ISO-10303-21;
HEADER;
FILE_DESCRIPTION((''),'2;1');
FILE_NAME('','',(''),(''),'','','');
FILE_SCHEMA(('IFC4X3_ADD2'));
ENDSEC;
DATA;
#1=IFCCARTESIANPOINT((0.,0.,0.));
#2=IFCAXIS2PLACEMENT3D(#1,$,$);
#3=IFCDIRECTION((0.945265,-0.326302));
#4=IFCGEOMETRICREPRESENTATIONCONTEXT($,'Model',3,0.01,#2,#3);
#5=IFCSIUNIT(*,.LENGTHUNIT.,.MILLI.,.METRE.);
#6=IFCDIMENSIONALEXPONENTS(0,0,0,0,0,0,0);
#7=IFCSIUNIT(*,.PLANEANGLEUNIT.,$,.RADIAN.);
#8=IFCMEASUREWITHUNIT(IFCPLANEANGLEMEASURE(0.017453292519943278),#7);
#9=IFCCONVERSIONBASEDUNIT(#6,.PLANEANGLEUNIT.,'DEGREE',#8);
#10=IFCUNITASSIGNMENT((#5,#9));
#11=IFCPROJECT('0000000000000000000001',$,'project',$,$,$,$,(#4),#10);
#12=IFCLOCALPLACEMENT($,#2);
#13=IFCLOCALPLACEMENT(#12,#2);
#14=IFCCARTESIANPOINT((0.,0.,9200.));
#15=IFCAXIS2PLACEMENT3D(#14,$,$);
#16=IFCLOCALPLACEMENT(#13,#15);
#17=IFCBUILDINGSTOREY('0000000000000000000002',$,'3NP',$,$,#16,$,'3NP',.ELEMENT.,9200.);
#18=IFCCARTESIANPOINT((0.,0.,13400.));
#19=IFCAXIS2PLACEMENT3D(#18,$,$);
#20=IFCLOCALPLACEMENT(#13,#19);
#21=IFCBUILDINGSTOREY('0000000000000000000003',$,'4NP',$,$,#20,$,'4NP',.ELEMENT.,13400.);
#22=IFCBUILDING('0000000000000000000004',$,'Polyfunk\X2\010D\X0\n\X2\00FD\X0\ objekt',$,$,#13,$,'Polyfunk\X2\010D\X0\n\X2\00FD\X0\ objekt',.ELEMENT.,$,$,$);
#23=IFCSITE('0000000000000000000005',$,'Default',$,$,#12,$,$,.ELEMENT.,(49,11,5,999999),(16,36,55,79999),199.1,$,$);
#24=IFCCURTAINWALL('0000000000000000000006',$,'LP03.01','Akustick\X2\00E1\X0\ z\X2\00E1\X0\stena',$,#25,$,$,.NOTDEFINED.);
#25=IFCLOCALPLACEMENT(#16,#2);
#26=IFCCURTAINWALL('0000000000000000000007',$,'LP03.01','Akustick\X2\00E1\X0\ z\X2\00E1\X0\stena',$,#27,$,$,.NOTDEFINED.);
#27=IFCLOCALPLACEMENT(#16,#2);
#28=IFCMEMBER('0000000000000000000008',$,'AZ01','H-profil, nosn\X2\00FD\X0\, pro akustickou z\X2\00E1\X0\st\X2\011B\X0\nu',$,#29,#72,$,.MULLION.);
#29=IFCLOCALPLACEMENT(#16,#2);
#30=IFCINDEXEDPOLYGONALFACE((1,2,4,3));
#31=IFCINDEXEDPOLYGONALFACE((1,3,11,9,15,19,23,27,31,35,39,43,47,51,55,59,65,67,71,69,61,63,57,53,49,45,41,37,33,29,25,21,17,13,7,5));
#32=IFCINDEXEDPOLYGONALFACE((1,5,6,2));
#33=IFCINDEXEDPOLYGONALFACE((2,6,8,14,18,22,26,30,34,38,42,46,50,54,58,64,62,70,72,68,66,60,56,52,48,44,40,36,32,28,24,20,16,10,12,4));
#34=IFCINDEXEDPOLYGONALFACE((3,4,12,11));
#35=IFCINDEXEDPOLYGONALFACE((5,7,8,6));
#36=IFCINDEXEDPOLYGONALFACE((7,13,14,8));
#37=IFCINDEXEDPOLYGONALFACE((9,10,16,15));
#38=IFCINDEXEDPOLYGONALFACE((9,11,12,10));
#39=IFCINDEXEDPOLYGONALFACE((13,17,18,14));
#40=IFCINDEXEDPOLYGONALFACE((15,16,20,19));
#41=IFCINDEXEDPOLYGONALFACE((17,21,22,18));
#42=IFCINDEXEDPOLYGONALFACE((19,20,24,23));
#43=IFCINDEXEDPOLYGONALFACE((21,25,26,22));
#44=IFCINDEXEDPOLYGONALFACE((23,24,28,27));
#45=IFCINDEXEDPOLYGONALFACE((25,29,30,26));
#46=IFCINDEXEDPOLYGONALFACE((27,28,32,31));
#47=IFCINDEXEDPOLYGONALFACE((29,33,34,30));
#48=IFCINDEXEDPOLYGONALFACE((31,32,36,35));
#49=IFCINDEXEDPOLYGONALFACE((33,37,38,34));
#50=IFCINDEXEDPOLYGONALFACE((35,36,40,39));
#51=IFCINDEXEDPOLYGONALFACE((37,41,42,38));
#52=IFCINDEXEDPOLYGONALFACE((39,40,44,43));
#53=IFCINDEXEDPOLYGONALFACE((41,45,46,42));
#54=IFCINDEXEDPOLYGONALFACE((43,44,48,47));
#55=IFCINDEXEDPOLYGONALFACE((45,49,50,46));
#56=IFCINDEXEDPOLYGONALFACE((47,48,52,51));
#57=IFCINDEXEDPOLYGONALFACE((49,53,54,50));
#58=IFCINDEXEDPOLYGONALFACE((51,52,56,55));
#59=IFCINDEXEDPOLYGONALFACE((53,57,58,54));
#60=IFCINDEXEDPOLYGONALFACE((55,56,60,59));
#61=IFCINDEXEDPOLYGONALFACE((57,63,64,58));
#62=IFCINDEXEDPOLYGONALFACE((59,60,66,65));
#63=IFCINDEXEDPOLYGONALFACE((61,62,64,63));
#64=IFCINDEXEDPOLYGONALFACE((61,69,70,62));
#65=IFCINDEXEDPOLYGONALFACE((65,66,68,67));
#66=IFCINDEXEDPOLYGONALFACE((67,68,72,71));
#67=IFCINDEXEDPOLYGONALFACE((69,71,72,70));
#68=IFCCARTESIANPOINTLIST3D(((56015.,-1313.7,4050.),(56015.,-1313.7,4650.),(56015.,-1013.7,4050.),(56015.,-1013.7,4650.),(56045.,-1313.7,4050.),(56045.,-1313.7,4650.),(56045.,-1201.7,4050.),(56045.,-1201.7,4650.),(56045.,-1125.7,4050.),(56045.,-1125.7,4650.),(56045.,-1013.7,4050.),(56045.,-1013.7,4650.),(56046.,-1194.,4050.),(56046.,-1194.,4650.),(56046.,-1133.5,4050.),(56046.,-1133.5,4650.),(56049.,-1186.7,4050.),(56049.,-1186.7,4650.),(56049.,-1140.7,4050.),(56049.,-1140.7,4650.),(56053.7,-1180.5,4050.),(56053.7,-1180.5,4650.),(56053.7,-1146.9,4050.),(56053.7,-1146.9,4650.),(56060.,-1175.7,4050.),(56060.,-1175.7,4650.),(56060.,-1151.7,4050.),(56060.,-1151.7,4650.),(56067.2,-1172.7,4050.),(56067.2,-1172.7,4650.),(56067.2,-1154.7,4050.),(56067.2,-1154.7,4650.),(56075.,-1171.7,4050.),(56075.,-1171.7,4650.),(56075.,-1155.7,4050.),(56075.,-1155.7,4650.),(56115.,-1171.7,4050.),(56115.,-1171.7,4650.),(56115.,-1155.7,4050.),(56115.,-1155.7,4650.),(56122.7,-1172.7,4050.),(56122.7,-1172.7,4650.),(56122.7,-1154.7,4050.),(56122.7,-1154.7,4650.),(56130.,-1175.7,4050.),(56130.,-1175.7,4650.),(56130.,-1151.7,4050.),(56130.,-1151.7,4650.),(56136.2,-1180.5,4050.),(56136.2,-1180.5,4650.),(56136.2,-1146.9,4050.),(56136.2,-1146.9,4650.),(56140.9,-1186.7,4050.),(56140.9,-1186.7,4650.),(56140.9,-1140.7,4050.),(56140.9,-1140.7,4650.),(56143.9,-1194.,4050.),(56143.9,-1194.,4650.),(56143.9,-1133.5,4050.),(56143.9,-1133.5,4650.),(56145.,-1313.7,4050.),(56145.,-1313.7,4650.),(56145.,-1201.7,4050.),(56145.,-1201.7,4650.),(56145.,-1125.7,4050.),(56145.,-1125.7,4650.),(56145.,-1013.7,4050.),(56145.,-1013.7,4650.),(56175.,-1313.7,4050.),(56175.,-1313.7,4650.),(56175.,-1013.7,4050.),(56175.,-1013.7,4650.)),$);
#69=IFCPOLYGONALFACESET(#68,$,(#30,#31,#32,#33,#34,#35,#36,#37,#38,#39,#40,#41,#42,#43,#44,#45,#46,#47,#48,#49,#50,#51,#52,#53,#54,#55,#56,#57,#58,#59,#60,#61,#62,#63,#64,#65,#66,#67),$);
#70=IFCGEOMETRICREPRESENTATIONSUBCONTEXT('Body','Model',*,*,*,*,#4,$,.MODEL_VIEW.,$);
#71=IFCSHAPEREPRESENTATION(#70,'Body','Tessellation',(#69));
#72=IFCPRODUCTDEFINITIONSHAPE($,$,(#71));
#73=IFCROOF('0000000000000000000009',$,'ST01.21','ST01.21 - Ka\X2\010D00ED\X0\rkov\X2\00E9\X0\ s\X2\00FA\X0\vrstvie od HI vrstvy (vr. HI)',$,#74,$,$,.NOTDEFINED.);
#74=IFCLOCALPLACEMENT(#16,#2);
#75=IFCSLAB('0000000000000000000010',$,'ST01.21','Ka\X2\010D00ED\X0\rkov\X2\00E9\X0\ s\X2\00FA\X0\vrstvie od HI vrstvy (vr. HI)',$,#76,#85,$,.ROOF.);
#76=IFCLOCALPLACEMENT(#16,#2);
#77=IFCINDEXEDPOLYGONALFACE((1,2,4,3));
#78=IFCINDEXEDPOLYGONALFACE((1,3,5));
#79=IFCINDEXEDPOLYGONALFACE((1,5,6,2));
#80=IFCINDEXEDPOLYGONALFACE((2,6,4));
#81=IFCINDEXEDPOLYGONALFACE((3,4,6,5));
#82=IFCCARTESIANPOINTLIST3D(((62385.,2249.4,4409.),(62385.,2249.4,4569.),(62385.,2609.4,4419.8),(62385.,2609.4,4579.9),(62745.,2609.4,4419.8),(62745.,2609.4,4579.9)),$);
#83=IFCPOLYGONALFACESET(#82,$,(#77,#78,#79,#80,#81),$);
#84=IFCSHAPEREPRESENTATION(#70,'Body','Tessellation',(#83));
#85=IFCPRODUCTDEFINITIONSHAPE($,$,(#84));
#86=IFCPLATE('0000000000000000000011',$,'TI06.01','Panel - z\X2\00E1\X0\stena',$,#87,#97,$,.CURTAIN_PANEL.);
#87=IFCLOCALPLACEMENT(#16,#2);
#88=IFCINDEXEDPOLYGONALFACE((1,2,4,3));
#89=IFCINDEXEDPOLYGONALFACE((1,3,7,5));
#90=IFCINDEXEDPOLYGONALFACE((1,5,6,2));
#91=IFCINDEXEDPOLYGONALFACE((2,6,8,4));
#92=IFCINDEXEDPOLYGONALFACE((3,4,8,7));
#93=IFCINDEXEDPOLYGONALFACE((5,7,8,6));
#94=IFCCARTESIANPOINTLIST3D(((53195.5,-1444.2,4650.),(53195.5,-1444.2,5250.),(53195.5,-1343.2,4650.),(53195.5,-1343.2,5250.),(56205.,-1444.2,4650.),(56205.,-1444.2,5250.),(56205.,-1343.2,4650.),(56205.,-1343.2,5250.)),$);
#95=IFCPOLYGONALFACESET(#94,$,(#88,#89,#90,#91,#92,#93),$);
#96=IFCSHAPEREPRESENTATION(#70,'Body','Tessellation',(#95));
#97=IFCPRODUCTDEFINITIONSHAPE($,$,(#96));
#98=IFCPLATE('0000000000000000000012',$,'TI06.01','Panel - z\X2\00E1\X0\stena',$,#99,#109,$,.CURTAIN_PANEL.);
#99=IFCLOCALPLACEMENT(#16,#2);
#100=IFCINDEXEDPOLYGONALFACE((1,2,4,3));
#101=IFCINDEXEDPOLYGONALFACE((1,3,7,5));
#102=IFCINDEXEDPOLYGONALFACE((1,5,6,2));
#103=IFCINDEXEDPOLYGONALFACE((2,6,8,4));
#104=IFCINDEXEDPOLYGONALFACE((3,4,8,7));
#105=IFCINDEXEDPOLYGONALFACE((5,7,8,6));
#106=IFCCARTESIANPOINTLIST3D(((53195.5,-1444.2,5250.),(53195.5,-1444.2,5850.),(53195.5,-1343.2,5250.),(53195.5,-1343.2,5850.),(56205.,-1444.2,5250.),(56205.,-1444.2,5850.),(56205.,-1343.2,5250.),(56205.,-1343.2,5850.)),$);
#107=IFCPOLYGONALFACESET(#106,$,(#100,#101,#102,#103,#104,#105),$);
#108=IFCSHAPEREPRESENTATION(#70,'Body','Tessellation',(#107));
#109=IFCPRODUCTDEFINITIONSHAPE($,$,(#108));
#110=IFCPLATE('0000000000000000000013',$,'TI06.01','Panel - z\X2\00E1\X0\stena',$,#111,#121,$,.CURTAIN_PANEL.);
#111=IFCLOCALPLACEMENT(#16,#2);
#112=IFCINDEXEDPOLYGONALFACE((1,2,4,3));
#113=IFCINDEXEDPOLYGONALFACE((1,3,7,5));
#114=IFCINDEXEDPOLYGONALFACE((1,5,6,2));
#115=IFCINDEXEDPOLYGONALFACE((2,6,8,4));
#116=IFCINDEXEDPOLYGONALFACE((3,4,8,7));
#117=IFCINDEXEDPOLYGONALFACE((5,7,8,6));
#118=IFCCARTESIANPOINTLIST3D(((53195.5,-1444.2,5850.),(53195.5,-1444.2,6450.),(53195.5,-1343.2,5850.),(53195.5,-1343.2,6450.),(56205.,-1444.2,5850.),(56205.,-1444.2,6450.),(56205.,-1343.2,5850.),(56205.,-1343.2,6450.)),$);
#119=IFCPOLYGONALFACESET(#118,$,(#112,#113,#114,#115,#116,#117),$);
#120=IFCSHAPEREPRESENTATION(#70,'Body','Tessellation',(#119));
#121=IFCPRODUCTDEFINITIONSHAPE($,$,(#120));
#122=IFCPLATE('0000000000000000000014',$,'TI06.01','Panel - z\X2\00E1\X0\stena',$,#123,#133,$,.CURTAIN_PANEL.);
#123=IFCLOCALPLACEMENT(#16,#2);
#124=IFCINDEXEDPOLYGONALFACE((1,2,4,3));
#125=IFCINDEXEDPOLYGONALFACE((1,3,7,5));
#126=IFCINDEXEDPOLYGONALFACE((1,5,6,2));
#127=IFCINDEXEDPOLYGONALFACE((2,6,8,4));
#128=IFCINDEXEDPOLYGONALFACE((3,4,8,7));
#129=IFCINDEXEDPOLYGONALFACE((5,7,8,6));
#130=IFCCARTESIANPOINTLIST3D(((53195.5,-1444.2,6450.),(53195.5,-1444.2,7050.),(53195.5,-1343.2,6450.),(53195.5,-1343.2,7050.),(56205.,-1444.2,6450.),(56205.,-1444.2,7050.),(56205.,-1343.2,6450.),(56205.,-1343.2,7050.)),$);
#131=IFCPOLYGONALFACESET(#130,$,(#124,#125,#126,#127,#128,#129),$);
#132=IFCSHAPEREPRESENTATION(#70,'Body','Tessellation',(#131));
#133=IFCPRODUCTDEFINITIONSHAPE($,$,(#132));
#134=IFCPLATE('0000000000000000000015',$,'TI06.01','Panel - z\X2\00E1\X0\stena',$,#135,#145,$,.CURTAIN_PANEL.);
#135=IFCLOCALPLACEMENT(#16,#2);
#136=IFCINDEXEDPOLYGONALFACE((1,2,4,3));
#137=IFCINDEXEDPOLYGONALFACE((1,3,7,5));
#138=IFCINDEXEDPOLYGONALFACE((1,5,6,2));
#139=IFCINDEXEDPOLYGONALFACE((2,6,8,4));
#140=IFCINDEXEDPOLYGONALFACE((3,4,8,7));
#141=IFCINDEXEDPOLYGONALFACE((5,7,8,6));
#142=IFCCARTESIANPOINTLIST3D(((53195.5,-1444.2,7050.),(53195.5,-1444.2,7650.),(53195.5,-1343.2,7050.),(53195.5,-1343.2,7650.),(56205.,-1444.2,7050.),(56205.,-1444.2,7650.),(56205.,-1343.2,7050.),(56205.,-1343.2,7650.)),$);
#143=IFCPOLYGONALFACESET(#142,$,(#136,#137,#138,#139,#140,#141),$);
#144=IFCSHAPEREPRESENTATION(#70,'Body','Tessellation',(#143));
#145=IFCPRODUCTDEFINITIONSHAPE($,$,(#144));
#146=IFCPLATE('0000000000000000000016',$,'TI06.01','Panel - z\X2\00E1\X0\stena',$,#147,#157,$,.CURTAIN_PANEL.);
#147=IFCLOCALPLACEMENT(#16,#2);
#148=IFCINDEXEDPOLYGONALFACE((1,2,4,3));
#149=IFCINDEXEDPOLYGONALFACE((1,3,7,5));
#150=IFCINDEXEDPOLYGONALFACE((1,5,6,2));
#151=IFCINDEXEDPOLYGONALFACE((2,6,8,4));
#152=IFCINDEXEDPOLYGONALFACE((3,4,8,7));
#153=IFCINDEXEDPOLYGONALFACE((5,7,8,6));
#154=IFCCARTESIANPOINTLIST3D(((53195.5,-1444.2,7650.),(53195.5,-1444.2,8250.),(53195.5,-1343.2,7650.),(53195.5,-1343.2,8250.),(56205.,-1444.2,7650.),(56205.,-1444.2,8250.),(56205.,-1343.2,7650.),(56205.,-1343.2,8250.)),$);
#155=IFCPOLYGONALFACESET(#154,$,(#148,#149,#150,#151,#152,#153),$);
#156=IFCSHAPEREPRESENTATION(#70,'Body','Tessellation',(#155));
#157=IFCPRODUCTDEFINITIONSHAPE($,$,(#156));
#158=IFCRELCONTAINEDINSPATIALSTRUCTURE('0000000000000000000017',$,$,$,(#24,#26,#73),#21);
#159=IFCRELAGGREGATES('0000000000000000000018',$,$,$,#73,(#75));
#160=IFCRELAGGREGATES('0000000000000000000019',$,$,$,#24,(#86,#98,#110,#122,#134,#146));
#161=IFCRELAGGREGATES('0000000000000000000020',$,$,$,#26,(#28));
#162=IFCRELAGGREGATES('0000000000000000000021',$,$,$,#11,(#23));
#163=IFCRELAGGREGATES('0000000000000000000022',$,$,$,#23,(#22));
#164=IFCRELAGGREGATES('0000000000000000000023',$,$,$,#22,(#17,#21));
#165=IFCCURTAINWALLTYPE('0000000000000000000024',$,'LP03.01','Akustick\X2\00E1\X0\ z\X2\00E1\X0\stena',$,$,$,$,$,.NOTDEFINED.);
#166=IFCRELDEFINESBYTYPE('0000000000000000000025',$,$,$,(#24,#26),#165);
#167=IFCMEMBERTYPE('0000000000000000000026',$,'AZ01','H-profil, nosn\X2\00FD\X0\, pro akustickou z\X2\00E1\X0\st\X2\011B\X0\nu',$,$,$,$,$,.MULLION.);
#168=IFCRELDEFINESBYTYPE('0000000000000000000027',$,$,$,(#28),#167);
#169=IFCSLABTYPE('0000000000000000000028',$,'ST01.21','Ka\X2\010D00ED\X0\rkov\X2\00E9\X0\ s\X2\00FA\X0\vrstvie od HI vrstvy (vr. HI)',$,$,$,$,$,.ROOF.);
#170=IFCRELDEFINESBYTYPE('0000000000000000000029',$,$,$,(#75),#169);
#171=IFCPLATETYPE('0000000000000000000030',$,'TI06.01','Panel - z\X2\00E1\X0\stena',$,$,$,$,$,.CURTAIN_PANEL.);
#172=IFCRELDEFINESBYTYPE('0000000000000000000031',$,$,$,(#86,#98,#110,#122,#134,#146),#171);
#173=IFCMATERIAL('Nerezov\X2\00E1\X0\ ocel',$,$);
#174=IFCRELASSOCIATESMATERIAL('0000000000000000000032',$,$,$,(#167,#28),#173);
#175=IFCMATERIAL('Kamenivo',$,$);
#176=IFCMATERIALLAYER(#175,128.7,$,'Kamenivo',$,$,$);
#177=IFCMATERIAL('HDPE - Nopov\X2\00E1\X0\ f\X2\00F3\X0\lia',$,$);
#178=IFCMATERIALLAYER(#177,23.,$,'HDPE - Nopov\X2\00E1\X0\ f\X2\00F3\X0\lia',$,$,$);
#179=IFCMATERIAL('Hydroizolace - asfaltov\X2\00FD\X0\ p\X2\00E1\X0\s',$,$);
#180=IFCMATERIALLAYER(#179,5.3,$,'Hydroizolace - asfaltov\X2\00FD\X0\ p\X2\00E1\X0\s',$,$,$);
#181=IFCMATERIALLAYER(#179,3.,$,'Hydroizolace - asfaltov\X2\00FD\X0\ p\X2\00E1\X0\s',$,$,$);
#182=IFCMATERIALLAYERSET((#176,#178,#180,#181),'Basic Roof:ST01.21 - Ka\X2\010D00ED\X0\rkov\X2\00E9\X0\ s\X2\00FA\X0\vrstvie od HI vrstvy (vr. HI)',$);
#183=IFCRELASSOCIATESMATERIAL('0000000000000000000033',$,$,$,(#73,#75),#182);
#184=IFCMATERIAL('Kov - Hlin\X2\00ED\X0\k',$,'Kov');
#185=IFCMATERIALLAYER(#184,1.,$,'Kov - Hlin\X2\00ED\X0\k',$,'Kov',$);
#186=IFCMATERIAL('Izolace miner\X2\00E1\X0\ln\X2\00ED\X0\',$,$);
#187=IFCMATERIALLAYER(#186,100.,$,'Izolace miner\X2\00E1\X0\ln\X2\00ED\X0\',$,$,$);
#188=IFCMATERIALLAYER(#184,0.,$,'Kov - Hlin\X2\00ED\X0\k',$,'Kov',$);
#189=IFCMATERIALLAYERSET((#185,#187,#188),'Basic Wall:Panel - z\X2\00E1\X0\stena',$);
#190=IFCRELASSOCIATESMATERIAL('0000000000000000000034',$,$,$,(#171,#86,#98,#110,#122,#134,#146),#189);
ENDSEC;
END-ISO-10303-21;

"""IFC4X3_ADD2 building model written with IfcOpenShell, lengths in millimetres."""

from ifc_helpers import new_model, entity, si_unit, converted_unit, direction, frame, frame_2d, origin, place, context, subcontext, project, spatial, polyline, circle_curve, parameter, trimmed, segment, composite_curve, rectangle, outline, extrude, source, transform, mapped, material, layer, layer_set, layer_usage, material_profile, profile_set, profile_usage, type_object, element, aggregate, save


model = new_model("IFC4X3_ADD2")

# Units and contexts
model_context = context("Model", 3, precision=0.01, world=origin(), true_north=direction((0.945265, -0.326302)))
body_context = subcontext(model_context, "Body", "Model", "MODEL_VIEW")
ifc_project = project(units=[si_unit("LENGTHUNIT", "METRE", prefix="MILLI"), converted_unit("PLANEANGLEUNIT", "DEGREE", entity("IfcPlaneAngleMeasure", 0.017453292519943278), si_unit("PLANEANGLEUNIT", "RADIAN"), dimensions=[0, 0, 0, 0, 0, 0, 0])], contexts=[model_context])

# Site, building, storey
site_placement = place(None, origin())
site = spatial("IfcSite", under=ifc_project, at=site_placement, Name="Default", CompositionType="ELEMENT", RefLatitude=(49, 11, 5, 999999), RefLongitude=(16, 36, 55, 79999), RefElevation=199.1)
building_placement = place(site_placement, origin())
building = spatial("IfcBuilding", under=site, at=building_placement, Name="Polyfunkčný objekt", LongName="Polyfunkčný objekt", CompositionType="ELEMENT")
storey_1_placement = place(building_placement, frame((0.0, 0.0, 9200.0)))
storey_1 = spatial("IfcBuildingStorey", under=building, at=storey_1_placement, Name="3NP", LongName="3NP", CompositionType="ELEMENT", Elevation=9200.0)

# Shared definitions
storey_2_placement = place(building_placement, frame((0.0, 0.0, 13400.0)))
storey_2 = spatial("IfcBuildingStorey", under=building, at=storey_2_placement, Name="4NP", LongName="4NP", CompositionType="ELEMENT", Elevation=13400.0)

# Curtain walls, member
curtain_wall_type_1 = type_object("IfcCurtainWallType", Name="LP03.01", Description="Akustická zástena", PredefinedType="NOTDEFINED")
curtain_wall_1_placement = place(storey_2_placement, frame((0.0, 0.0, -13400.0)))
curtain_wall_1 = element("IfcCurtainWall", 1, at=curtain_wall_1_placement, inside=storey_2, type_object=curtain_wall_type_1, Name="LP03.01", Description="Akustická zástena", PredefinedType="NOTDEFINED")
ifc_material_1 = material(Name="Nerezová ocel")
ifc_material_profile_1 = material_profile(ifc_material_1, outline(composite_curve([segment(polyline([(50.0, -150.0), (80.0, -150.0)]), True, "CONTINUOUS"), segment(polyline([(80.0, -150.0), (80.0, 150.0)]), True, "CONTINUOUS"), segment(polyline([(80.0, 150.0), (50.0, 150.0)]), True, "CONTINUOUS"), segment(polyline([(50.0, 150.0), (50.0, 38.0)]), True, "CONTINUOUS"), segment(trimmed(circle_curve(frame_2d((20.0, 38.0), x_axis=(0.0, 1.0)), 30.0), [parameter(180.0)], [parameter(270.0)], True, "PARAMETER"), False, "CONTINUOUS"), segment(polyline([(20.0, 8.0), (-20.0, 8.0)]), True, "CONTINUOUS"), segment(trimmed(circle_curve(frame_2d((-20.0, 38.0), x_axis=(0.0, 1.0)), 30.0), [parameter(90.0)], [parameter(180.0)], True, "PARAMETER"), False, "CONTINUOUS"), segment(polyline([(-50.0, 38.0), (-50.0, 150.0)]), True, "CONTINUOUS"), segment(polyline([(-50.0, 150.0), (-80.0, 150.0)]), True, "CONTINUOUS"), segment(polyline([(-80.0, 150.0), (-80.0, -150.0)]), True, "CONTINUOUS"), segment(polyline([(-80.0, -150.0), (-50.0, -150.0)]), True, "CONTINUOUS"), segment(polyline([(-50.0, -150.0), (-50.0, -38.0)]), True, "CONTINUOUS"), segment(trimmed(circle_curve(frame_2d((-20.0, -38.0), x_axis=(0.0, 1.0)), 30.0), [parameter(0.0)], [parameter(90.0)], True, "PARAMETER"), False, "CONTINUOUS"), segment(polyline([(-20.0, -8.0), (20.0, -8.0)]), True, "CONTINUOUS"), segment(trimmed(circle_curve(frame_2d((20.0, -38.0), x_axis=(0.0, 1.0)), 30.0), [parameter(270.0)], [parameter(0.0)], True, "PARAMETER"), False, "CONTINUOUS"), segment(polyline([(50.0, -38.0), (50.0, -150.0)]), True, "CONTINUOUS")], self_intersect=False)), Name="Profil zástena")
ifc_profile_set_1 = profile_set([ifc_material_profile_1], Name="Profil zástena")
ifc_profile_usage_1 = profile_usage(ifc_profile_set_1)
member_type_1 = type_object("IfcMemberType", Name="AZ01", Description="H-profil, nosný, pro akustickou zástěnu", PredefinedType="MULLION", material=ifc_profile_set_1)
curtain_wall_2_placement = place(storey_2_placement, frame((0.0, 0.0, -13400.0)))
curtain_wall_2 = element("IfcCurtainWall", 2, at=curtain_wall_2_placement, inside=storey_2, type_object=curtain_wall_type_1, Name="LP03.01", Description="Akustická zástena", PredefinedType="NOTDEFINED")
shared_shape_1 = source(origin(), body_context, "Body", "SweptSolid", [
    extrude(outline(composite_curve([segment(polyline([(50.0, -150.0), (80.0, -150.0)]), True, "CONTINUOUS"), segment(polyline([(80.0, -150.0), (80.0, 150.0)]), True, "CONTINUOUS"), segment(polyline([(80.0, 150.0), (50.0, 150.0)]), True, "CONTINUOUS"), segment(polyline([(50.0, 150.0), (50.0, 38.0)]), True, "CONTINUOUS"), segment(trimmed(circle_curve(frame_2d((20.0, 38.0), x_axis=(0.0, 1.0)), 30.0), [parameter(180.0)], [parameter(270.0)], True, "PARAMETER"), False, "CONTINUOUS"), segment(polyline([(20.0, 8.0), (-20.0, 8.0)]), True, "CONTINUOUS"), segment(trimmed(circle_curve(frame_2d((-20.0, 38.0), x_axis=(0.0, 1.0)), 30.0), [parameter(90.0)], [parameter(180.0)], True, "PARAMETER"), False, "CONTINUOUS"), segment(polyline([(-50.0, 38.0), (-50.0, 150.0)]), True, "CONTINUOUS"), segment(polyline([(-50.0, 150.0), (-80.0, 150.0)]), True, "CONTINUOUS"), segment(polyline([(-80.0, 150.0), (-80.0, -150.0)]), True, "CONTINUOUS"), segment(polyline([(-80.0, -150.0), (-50.0, -150.0)]), True, "CONTINUOUS"), segment(polyline([(-50.0, -150.0), (-50.0, -38.0)]), True, "CONTINUOUS"), segment(trimmed(circle_curve(frame_2d((-20.0, -38.0), x_axis=(0.0, 1.0)), 30.0), [parameter(0.0)], [parameter(90.0)], True, "PARAMETER"), False, "CONTINUOUS"), segment(polyline([(-20.0, -8.0), (20.0, -8.0)]), True, "CONTINUOUS"), segment(trimmed(circle_curve(frame_2d((20.0, -38.0), x_axis=(0.0, 1.0)), 30.0), [parameter(270.0)], [parameter(0.0)], True, "PARAMETER"), False, "CONTINUOUS"), segment(polyline([(50.0, -38.0), (50.0, -150.0)]), True, "CONTINUOUS")], self_intersect=False)), frame((-150.0, 0.0, -600.0), z_axis=(0.0, 0.0, 1.0), x_axis=(0.0, 1.0, 0.0)), (0.0, 0.0, 1.0), 600.0),
])
member_1_placement = place(curtain_wall_2_placement, frame((56095.0, -1313.7, 13850.0), z_axis=(0.0, 0.0, 1.0), x_axis=(0.0, -1.0, 0.0)))
member_1 = element("IfcMember", 3, at=member_1_placement, type_object=member_type_1, material=ifc_profile_usage_1, Name="AZ01", Description="H-profil, nosný, pro akustickou zástěnu", PredefinedType="MULLION", context=body_context, shape_type="MappedRepresentation", body=[
    mapped(shared_shape_1, transform((0.0, 0.0, 0.0), scale=1.0)),
])

# Roof, slab
ifc_material_2 = material(Name="Kamenivo")
ifc_layer_1 = layer(ifc_material_2, 128.7, Name="Kamenivo")
ifc_material_3 = material(Name="HDPE - Nopová fólia")
ifc_layer_2 = layer(ifc_material_3, 23.0, Name="HDPE - Nopová fólia")
ifc_material_4 = material(Name="Hydroizolace - asfaltový pás")
ifc_layer_3 = layer(ifc_material_4, 5.3, Name="Hydroizolace - asfaltový pás")
ifc_layer_4 = layer(ifc_material_4, 3.0, Name="Hydroizolace - asfaltový pás")
ifc_layer_set_1 = layer_set([ifc_layer_1, ifc_layer_2, ifc_layer_3, ifc_layer_4], Name="Basic Roof:ST01.21 - Kačírkové súvrstvie od HI vrstvy (vr. HI)")
roof_placement = place(storey_2_placement, frame((62385.0, 2249.4, 209.0)))
roof = element("IfcRoof", 4, at=roof_placement, inside=storey_2, material=ifc_layer_set_1, Name="ST01.21", Description="ST01.21 - Kačírkové súvrstvie od HI vrstvy (vr. HI)", PredefinedType="NOTDEFINED")
slab_type = type_object("IfcSlabType", Name="ST01.21", Description="Kačírkové súvrstvie od HI vrstvy (vr. HI)", PredefinedType="ROOF")
slab_placement = place(roof_placement, origin())
slab = element("IfcSlab", 5, at=slab_placement, type_object=slab_type, material=ifc_layer_set_1, Name="ST01.21", Description="Kačírkové súvrstvie od HI vrstvy (vr. HI)", PredefinedType="ROOF", context=body_context, shape_type="SweptSolid", body=[
    extrude(outline(polyline([(-180.0, 180.1), (-180.0, -180.1), (180.0, 180.1), (-180.0, 180.1)])), frame((180.0, 180.0, 5.4), z_axis=(0.0, -0.030015, 0.999549), x_axis=(1.0, 0.0, 0.0)), (0.0, 0.030015, 0.999549), 160.1),
])
aggregate(roof, [slab])

# Plates
ifc_material_5 = material(Name="Kov - Hliník", Category="Kov")
ifc_layer_5 = layer(ifc_material_5, 1.0, Name="Kov - Hliník", Category="Kov")
ifc_material_6 = material(Name="Izolace minerální")
ifc_layer_6 = layer(ifc_material_6, 100.0, Name="Izolace minerální")
ifc_layer_7 = layer(ifc_material_5, 0.0, Name="Kov - Hliník", Category="Kov")
ifc_layer_set_2 = layer_set([ifc_layer_5, ifc_layer_6, ifc_layer_7], Name="Basic Wall:Panel - zástena")
ifc_layer_usage_1 = layer_usage(ifc_layer_set_2, "AXIS2", "POSITIVE", -50.5)
plate_type = type_object("IfcPlateType", Name="TI06.01", Description="Panel - zástena", PredefinedType="CURTAIN_PANEL", material=ifc_layer_set_2)
plate_1_placement = place(storey_2_placement, frame((53195.5, -1393.7, 450.0)))
plate_1 = element("IfcPlate", 6, at=plate_1_placement, type_object=plate_type, material=ifc_layer_usage_1, Name="TI06.01", Description="Panel - zástena", PredefinedType="CURTAIN_PANEL", context=body_context, shape_type="SweptSolid", body=[
    extrude(rectangle(XDim=101.0, YDim=3009.5, at=frame_2d((0.0, 0.0), x_axis=(1.0, 0.0))), frame((1504.7, 0.0, 0.0), z_axis=(0.0, 0.0, 1.0), x_axis=(0.0, 1.0, 0.0)), (0.0, 0.0, 1.0), 600.0),
])
ifc_layer_usage_2 = layer_usage(ifc_layer_set_2, "AXIS2", "POSITIVE", -50.5)
plate_2_placement = place(storey_2_placement, frame((53195.5, -1393.7, 1050.0)))
plate_2 = element("IfcPlate", 7, at=plate_2_placement, type_object=plate_type, material=ifc_layer_usage_2, Name="TI06.01", Description="Panel - zástena", PredefinedType="CURTAIN_PANEL", context=body_context, shape_type="SweptSolid", body=[
    extrude(rectangle(XDim=101.0, YDim=3009.5, at=frame_2d((0.0, 0.0), x_axis=(1.0, 0.0))), frame((1504.7, 0.0, 0.0), z_axis=(0.0, 0.0, 1.0), x_axis=(0.0, 1.0, 0.0)), (0.0, 0.0, 1.0), 600.0),
])
ifc_layer_usage_3 = layer_usage(ifc_layer_set_2, "AXIS2", "POSITIVE", -50.5)
plate_3_placement = place(storey_2_placement, frame((53195.5, -1393.7, 1650.0)))
plate_3 = element("IfcPlate", 8, at=plate_3_placement, type_object=plate_type, material=ifc_layer_usage_3, Name="TI06.01", Description="Panel - zástena", PredefinedType="CURTAIN_PANEL", context=body_context, shape_type="SweptSolid", body=[
    extrude(rectangle(XDim=101.0, YDim=3009.5, at=frame_2d((0.0, 0.0), x_axis=(1.0, 0.0))), frame((1504.7, 0.0, 0.0), z_axis=(0.0, 0.0, 1.0), x_axis=(0.0, 1.0, 0.0)), (0.0, 0.0, 1.0), 600.0),
])
ifc_layer_usage_4 = layer_usage(ifc_layer_set_2, "AXIS2", "POSITIVE", -50.5)
plate_4_placement = place(storey_2_placement, frame((53195.5, -1393.7, 2250.0)))
plate_4 = element("IfcPlate", 9, at=plate_4_placement, type_object=plate_type, material=ifc_layer_usage_4, Name="TI06.01", Description="Panel - zástena", PredefinedType="CURTAIN_PANEL", context=body_context, shape_type="SweptSolid", body=[
    extrude(rectangle(XDim=101.0, YDim=3009.5, at=frame_2d((0.0, 0.0), x_axis=(1.0, 0.0))), frame((1504.7, 0.0, 0.0), z_axis=(0.0, 0.0, 1.0), x_axis=(0.0, 1.0, 0.0)), (0.0, 0.0, 1.0), 600.0),
])
ifc_layer_usage_5 = layer_usage(ifc_layer_set_2, "AXIS2", "POSITIVE", -50.5)
plate_5_placement = place(storey_2_placement, frame((53195.5, -1393.7, 2850.0)))
plate_5 = element("IfcPlate", 10, at=plate_5_placement, type_object=plate_type, material=ifc_layer_usage_5, Name="TI06.01", Description="Panel - zástena", PredefinedType="CURTAIN_PANEL", context=body_context, shape_type="SweptSolid", body=[
    extrude(rectangle(XDim=101.0, YDim=3009.5, at=frame_2d((0.0, 0.0), x_axis=(1.0, 0.0))), frame((1504.7, 0.0, 0.0), z_axis=(0.0, 0.0, 1.0), x_axis=(0.0, 1.0, 0.0)), (0.0, 0.0, 1.0), 600.0),
])
ifc_layer_usage_6 = layer_usage(ifc_layer_set_2, "AXIS2", "POSITIVE", -50.5)
plate_6_placement = place(storey_2_placement, frame((53195.5, -1393.7, 3450.0)))
plate_6 = element("IfcPlate", 11, at=plate_6_placement, type_object=plate_type, material=ifc_layer_usage_6, Name="TI06.01", Description="Panel - zástena", PredefinedType="CURTAIN_PANEL", context=body_context, shape_type="SweptSolid", body=[
    extrude(rectangle(XDim=101.0, YDim=3009.5, at=frame_2d((0.0, 0.0), x_axis=(1.0, 0.0))), frame((1504.7, 0.0, 0.0), z_axis=(0.0, 0.0, 1.0), x_axis=(0.0, 1.0, 0.0)), (0.0, 0.0, 1.0), 600.0),
])
aggregate(curtain_wall_1, [plate_1, plate_2, plate_3, plate_4, plate_5, plate_6])
aggregate(curtain_wall_2, [member_1])

save(model, "model.ifc")
